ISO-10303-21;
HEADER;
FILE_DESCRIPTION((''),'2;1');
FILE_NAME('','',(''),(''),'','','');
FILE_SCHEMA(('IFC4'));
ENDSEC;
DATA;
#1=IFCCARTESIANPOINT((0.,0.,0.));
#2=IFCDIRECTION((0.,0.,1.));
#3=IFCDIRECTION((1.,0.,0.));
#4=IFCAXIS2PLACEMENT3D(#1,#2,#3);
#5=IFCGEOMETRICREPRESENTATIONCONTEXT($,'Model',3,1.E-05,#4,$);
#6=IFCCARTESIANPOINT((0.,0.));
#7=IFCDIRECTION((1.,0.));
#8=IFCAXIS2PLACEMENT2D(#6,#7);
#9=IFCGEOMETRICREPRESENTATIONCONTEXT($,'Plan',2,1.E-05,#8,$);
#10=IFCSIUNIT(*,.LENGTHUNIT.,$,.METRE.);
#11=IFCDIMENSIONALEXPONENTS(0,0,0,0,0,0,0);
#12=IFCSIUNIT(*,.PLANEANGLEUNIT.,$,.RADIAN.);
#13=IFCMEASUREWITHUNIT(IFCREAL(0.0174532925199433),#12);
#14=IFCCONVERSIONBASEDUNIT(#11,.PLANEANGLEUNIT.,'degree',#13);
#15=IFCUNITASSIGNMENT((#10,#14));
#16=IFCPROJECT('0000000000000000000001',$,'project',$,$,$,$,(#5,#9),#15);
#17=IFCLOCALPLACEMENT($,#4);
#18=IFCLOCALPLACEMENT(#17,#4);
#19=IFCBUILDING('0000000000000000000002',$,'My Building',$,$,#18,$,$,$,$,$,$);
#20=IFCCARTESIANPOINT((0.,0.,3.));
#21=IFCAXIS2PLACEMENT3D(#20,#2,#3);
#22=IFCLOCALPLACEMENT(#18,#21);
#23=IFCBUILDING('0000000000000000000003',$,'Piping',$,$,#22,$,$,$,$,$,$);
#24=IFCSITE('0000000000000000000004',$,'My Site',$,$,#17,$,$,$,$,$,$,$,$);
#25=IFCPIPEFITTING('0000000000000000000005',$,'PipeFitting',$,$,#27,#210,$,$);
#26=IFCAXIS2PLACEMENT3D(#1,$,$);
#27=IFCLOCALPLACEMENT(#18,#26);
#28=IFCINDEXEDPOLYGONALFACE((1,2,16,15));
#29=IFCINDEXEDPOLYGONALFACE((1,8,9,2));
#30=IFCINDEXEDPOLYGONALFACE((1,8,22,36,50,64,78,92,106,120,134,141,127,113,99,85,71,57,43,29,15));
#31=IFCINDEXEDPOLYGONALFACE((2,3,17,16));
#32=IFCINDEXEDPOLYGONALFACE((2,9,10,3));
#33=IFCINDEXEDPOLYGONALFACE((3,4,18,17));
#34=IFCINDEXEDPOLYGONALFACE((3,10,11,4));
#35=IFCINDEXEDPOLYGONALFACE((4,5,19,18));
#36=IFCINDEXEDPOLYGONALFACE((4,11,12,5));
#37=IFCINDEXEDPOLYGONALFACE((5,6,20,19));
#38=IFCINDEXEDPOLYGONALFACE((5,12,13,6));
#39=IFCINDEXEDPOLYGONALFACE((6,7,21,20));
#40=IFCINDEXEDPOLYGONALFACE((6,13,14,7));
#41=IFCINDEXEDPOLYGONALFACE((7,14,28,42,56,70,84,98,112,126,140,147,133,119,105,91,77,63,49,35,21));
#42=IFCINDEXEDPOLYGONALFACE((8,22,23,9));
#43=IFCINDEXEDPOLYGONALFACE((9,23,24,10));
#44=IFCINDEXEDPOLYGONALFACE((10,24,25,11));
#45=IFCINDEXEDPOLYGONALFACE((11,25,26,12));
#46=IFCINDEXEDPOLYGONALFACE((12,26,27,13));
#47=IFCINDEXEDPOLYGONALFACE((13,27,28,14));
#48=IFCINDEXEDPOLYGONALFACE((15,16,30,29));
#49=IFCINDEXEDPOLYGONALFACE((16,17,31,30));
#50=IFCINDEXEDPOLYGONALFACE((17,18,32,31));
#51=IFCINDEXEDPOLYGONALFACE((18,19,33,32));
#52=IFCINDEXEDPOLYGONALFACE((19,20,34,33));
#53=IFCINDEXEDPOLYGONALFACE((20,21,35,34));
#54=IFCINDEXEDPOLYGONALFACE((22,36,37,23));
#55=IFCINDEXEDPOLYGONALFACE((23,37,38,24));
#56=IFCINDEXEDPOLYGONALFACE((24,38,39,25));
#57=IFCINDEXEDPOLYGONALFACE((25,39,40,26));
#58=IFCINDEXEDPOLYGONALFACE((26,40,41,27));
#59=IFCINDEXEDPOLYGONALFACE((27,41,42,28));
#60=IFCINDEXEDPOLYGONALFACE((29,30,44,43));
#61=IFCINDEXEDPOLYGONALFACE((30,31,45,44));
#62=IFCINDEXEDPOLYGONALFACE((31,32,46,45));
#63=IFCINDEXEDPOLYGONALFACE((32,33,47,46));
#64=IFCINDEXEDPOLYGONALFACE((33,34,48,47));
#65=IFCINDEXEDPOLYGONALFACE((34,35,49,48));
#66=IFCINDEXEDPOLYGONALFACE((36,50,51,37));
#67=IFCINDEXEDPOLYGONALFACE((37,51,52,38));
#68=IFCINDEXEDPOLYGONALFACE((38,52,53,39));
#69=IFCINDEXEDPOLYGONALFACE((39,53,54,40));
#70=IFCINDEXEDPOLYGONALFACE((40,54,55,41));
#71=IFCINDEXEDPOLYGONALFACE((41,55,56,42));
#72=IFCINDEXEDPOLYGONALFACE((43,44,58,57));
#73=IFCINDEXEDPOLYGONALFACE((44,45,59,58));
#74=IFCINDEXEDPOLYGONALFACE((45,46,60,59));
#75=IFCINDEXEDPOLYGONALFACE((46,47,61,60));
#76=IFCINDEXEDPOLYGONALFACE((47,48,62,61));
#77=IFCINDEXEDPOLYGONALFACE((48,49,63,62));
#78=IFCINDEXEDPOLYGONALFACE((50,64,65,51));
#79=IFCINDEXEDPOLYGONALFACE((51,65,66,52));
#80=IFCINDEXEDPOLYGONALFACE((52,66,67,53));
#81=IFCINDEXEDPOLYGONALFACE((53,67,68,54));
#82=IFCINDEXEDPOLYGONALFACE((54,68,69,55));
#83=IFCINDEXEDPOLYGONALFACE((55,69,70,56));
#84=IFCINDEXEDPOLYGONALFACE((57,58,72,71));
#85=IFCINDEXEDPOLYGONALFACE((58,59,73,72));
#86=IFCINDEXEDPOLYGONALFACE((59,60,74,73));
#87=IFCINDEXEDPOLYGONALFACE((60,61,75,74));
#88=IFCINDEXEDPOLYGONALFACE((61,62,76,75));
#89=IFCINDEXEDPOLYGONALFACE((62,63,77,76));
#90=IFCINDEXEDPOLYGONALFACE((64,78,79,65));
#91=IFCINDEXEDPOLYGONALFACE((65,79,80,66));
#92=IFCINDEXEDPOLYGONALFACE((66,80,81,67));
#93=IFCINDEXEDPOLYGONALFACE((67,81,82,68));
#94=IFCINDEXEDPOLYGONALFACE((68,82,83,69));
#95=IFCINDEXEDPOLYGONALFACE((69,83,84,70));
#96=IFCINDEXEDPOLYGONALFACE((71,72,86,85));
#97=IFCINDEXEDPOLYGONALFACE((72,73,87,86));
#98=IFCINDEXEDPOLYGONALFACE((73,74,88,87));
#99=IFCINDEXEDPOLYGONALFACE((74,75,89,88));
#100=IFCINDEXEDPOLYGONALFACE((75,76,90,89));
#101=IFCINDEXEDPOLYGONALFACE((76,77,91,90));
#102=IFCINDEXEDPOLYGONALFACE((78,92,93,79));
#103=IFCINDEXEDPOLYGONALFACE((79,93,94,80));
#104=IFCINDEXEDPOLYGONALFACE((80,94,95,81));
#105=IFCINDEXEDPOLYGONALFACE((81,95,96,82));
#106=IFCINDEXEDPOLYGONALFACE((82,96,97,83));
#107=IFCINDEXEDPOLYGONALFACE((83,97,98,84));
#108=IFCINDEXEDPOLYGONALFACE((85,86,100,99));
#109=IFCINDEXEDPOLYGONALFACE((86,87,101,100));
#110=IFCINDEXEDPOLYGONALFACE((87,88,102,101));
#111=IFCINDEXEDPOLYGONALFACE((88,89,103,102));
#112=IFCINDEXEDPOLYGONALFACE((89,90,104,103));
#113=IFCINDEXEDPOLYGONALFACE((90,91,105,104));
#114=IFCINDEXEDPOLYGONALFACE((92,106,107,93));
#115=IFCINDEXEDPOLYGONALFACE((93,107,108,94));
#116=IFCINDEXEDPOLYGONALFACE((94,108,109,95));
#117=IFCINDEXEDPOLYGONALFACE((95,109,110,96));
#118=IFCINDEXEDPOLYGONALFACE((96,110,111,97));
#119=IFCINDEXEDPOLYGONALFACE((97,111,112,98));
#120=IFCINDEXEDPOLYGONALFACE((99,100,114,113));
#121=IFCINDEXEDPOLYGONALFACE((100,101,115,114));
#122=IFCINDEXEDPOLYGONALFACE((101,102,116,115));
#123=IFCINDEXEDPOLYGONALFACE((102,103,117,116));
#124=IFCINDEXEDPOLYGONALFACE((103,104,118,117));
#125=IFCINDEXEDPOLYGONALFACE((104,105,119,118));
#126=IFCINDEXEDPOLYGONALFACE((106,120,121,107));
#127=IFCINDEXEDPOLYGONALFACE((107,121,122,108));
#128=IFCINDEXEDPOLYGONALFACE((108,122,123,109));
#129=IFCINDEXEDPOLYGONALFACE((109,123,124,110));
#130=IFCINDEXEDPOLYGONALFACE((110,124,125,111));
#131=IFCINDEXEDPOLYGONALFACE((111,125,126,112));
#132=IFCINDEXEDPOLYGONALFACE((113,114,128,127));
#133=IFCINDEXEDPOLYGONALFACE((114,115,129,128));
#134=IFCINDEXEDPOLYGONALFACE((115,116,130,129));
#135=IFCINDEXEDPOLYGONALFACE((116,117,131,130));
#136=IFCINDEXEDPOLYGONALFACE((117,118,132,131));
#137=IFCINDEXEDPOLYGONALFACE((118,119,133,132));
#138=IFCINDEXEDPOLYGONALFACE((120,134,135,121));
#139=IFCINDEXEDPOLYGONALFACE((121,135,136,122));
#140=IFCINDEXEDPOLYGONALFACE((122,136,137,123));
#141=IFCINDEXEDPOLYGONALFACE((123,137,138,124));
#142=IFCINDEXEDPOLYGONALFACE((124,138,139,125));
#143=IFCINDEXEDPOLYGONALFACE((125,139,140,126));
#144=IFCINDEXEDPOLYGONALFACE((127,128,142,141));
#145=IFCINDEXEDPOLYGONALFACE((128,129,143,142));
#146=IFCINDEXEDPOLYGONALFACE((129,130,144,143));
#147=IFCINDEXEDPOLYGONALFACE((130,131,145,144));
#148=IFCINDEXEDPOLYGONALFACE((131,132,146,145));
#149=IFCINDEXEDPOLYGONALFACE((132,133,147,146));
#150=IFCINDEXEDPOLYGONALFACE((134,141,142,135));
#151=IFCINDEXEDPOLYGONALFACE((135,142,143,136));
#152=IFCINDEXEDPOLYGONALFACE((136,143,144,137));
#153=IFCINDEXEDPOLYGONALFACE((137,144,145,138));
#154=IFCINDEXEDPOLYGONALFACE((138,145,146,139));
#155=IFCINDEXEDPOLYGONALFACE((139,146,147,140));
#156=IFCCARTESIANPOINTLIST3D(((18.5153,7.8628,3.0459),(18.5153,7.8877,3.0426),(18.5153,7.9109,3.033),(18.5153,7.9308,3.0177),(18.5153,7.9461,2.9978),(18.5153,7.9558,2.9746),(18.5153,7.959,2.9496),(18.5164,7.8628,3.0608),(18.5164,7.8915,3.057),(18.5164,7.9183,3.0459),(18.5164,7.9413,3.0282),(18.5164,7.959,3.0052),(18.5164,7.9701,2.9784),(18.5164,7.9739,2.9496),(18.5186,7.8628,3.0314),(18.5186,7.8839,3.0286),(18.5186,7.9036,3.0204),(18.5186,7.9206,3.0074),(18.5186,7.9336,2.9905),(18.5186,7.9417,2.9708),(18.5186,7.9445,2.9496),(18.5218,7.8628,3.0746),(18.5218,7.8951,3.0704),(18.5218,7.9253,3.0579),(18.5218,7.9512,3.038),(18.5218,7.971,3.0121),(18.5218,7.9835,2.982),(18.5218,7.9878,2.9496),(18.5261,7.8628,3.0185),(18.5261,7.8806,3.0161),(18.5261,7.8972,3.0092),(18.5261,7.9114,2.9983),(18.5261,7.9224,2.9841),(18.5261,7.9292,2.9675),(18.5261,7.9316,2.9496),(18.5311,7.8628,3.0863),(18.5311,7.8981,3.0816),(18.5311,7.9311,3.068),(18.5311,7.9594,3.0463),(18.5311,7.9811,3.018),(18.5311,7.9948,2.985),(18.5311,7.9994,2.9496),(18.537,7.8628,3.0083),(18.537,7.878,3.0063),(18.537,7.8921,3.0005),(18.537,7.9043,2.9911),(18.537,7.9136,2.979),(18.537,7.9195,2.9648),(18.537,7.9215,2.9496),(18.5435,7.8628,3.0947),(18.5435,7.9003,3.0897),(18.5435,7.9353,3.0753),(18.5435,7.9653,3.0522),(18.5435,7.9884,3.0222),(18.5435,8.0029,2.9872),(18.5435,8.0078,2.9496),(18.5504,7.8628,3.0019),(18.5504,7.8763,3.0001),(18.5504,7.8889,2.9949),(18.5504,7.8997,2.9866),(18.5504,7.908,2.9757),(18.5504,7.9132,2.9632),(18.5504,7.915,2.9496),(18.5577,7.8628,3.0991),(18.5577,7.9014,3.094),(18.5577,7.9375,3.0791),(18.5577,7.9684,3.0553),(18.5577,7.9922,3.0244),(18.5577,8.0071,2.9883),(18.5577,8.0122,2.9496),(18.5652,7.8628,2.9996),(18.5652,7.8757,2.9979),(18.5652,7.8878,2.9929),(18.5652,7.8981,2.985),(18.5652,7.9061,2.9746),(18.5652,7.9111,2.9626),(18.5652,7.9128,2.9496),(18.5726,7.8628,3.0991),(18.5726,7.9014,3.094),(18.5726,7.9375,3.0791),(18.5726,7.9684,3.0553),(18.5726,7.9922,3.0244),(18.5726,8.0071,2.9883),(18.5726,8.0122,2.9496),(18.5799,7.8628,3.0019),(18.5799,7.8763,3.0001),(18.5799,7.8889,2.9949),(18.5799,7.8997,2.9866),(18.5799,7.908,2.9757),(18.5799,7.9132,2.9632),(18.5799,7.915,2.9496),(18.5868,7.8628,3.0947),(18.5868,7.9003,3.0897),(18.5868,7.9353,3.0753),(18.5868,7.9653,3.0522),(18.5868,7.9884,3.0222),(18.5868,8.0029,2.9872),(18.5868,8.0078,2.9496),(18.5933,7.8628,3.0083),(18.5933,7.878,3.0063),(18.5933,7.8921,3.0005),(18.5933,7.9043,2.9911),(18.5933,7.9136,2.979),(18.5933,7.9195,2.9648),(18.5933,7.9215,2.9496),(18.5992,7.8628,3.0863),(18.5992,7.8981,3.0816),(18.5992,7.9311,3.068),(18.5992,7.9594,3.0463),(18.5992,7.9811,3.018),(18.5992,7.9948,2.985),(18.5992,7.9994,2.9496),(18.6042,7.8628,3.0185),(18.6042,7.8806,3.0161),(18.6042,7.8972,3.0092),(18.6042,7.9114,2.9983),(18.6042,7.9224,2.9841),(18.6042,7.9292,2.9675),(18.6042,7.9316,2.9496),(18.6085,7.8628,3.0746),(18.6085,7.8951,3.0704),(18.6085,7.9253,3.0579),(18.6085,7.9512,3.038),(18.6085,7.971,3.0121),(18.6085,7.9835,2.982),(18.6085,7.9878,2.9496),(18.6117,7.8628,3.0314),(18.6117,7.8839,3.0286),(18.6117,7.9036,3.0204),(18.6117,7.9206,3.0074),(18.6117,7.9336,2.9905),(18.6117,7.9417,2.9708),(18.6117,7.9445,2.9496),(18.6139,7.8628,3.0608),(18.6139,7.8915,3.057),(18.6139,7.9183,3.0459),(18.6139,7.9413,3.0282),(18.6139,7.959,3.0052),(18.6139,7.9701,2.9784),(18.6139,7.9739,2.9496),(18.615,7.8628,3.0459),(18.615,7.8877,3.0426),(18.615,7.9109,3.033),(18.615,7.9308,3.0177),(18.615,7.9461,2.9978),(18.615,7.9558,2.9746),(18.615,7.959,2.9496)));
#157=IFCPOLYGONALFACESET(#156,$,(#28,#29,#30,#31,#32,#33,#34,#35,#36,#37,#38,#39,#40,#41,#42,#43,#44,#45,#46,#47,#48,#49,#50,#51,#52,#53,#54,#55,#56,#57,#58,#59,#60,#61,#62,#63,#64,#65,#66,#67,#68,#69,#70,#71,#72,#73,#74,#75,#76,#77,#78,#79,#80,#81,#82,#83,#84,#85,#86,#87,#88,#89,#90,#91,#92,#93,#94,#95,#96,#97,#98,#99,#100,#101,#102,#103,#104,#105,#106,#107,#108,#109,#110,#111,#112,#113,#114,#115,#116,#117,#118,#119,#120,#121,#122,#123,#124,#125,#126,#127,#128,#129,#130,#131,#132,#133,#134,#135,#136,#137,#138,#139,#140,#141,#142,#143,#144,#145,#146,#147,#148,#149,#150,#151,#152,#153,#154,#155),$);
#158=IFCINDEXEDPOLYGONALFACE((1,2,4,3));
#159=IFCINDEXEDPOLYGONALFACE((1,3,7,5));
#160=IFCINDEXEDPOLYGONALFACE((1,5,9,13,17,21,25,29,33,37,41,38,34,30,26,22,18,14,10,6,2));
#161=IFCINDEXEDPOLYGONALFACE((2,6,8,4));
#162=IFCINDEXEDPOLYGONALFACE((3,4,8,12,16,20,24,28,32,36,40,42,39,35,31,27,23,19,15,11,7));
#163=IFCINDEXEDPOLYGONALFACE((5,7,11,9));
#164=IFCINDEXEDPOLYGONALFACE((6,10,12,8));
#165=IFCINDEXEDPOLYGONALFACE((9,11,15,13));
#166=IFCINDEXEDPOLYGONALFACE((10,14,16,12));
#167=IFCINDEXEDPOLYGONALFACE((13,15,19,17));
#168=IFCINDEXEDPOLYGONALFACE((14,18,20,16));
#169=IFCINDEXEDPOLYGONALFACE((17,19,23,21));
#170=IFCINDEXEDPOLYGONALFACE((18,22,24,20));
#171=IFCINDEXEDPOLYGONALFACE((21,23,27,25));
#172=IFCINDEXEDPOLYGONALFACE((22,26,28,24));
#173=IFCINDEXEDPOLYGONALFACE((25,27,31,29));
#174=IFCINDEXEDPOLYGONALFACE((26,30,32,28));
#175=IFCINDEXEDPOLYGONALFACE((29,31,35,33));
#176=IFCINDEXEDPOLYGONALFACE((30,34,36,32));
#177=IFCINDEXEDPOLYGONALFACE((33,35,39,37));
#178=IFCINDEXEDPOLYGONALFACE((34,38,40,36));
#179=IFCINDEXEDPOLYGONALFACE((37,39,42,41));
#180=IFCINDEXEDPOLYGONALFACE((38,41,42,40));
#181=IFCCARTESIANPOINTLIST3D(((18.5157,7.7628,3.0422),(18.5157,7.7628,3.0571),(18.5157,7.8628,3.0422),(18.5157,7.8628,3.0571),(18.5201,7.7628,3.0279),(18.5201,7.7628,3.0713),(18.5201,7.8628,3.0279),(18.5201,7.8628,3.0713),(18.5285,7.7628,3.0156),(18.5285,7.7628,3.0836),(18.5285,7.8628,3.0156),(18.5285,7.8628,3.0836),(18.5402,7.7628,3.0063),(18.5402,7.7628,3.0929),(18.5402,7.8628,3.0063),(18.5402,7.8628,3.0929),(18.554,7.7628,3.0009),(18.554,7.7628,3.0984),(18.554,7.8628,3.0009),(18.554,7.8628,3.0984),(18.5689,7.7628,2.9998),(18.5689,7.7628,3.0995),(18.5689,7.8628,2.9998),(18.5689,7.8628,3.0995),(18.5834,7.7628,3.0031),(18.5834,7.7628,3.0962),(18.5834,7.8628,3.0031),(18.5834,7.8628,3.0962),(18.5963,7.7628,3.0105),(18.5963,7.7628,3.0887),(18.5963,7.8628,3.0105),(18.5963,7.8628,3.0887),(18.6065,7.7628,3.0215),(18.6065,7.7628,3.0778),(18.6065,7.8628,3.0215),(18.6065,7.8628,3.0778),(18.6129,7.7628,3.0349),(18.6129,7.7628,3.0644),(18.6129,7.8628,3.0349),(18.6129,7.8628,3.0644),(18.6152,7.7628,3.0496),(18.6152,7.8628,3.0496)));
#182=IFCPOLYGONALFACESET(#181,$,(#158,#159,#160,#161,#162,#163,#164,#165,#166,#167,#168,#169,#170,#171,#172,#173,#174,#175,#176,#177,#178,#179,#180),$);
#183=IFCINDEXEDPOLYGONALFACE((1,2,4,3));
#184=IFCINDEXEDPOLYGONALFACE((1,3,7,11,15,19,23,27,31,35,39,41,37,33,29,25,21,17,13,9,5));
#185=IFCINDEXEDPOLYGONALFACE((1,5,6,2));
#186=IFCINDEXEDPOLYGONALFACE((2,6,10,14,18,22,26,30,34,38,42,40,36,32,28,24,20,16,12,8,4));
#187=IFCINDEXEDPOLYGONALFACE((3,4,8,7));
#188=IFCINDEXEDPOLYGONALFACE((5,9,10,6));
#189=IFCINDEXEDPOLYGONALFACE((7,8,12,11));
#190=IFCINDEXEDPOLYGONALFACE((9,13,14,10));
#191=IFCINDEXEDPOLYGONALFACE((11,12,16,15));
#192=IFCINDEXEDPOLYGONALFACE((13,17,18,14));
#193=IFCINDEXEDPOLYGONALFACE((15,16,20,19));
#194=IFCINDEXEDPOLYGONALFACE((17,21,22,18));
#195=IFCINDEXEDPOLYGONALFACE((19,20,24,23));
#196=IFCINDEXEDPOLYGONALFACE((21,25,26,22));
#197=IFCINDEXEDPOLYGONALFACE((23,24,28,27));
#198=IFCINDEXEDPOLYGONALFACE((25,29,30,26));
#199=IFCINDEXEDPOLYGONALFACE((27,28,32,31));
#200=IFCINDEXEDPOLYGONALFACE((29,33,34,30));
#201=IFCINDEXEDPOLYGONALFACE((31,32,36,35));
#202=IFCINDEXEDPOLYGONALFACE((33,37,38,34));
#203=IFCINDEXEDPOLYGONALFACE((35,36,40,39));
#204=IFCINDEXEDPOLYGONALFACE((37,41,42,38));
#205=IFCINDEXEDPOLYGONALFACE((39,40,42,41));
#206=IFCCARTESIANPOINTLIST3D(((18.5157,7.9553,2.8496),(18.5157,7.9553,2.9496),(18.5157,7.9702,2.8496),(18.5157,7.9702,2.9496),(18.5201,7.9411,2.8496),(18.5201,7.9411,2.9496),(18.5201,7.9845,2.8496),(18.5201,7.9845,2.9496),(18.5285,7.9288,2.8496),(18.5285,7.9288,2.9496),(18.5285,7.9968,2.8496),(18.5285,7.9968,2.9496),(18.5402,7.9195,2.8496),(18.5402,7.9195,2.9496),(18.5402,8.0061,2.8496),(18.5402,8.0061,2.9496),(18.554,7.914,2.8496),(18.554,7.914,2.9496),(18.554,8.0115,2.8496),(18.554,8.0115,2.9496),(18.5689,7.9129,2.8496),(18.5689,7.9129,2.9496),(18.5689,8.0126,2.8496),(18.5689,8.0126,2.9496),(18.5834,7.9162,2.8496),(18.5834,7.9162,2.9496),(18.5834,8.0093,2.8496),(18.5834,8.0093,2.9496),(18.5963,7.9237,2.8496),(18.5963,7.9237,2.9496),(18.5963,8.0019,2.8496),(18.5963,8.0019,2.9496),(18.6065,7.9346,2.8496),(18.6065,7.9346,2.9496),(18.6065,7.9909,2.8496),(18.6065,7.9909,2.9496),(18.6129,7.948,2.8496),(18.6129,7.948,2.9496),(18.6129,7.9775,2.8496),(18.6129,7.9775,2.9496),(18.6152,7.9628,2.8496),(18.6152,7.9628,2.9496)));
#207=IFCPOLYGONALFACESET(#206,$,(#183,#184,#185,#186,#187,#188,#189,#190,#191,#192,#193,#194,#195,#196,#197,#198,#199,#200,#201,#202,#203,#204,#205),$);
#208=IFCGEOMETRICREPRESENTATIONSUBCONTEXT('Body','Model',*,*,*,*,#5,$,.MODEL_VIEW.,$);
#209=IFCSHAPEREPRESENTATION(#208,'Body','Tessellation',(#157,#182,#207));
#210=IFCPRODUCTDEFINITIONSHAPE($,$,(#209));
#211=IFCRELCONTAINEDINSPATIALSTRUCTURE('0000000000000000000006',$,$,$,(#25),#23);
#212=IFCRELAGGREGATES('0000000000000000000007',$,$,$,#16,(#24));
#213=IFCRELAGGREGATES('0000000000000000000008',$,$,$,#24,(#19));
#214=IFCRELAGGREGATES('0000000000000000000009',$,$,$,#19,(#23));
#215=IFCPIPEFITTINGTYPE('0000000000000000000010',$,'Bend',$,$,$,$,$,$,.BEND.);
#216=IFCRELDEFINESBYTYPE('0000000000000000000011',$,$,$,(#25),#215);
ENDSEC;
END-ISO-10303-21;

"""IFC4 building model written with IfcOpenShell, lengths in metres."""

from ifc_helpers import new_model, entity, si_unit, converted_unit, frame, origin_with_axes, origin_2d_with_axis, place, context, subcontext, project, spatial, circle, extrude, source, transform, mapped, type_object, type_shapes, element, save


model = new_model("IFC4")

# Units and contexts
model_context = context("Model", 3, precision=1e-05, world=origin_with_axes())
plan_context = context("Plan", 2, precision=1e-05, world=origin_2d_with_axis())
body_context = subcontext(model_context, "Body", "Model", "MODEL_VIEW")
ifc_project = project(units=[si_unit("LENGTHUNIT", "METRE"), converted_unit("PLANEANGLEUNIT", "degree", entity("IfcReal", 0.0174532925199433), si_unit("PLANEANGLEUNIT", "RADIAN"), dimensions=[0, 0, 0, 0, 0, 0, 0])], contexts=[model_context, plan_context])

# Site, buildings
site_placement = place(None, origin_with_axes())
site = spatial("IfcSite", under=ifc_project, at=site_placement, Name="My Site")
building_1_placement = place(site_placement, origin_with_axes())
building_1 = spatial("IfcBuilding", under=site, at=building_1_placement, Name="My Building")
building_2_placement = place(building_1_placement, frame((0.0, 0.0, 3.0), z_axis=(0.0, 0.0, 1.0), x_axis=(1.0, 0.0, 0.0)))
building_2 = spatial("IfcBuilding", under=building_1, at=building_2_placement, Name="Piping")

# Pipe fitting
pipe_fitting_type_1 = type_object("IfcPipeFittingType", Name="Bend", PredefinedType="BEND")
shared_shape = source(origin_with_axes(), body_context, "Body", "SolidModel", [
    entity("IfcSweptDiskSolid", entity("IfcIndexedPolyCurve", entity("IfcCartesianPointList3D", [[0.0, 0.0, 0.1], [0.0, 0.0293, 0.1707], [0.0, 0.1, 0.2]]), [entity("IfcArcIndex", [1, 2, 3])]), 0.05),
    extrude(circle(Radius=0.05), origin_with_axes(), (0.0, 0.0, 1.0), 0.1),
    extrude(circle(Radius=0.05), frame((0.0, 0.1, 0.2), z_axis=(0.0, 1.0, 0.0), x_axis=(1.0, 0.0, 0.0)), (0.0, 0.0, 1.0), 0.1),
])
type_shapes(pipe_fitting_type_1, [shared_shape])
for number, where, z_axis, x_axis, name in (
    (1, (18.5652, 7.7628, 0.0496), (0.0, 1.0, 0.0), (1.0, 0.0, 0.0), "PipeFitting"),
):
    element("IfcPipeFitting", number, at=place(building_2_placement, frame(where, z_axis=z_axis, x_axis=x_axis)), inside=building_2, type_object=pipe_fitting_type_1, Name=name, context=body_context, shape_type="MappedRepresentation", body=[
        mapped(shared_shape, transform((0.0, 0.0, 0.0), x_axis=(1.0, 0.0, 0.0), y_axis=(0.0, 1.0, 0.0), z_axis=(0.0, 0.0, 1.0), scale=1.0)),
    ])

save(model, "model.ifc")
